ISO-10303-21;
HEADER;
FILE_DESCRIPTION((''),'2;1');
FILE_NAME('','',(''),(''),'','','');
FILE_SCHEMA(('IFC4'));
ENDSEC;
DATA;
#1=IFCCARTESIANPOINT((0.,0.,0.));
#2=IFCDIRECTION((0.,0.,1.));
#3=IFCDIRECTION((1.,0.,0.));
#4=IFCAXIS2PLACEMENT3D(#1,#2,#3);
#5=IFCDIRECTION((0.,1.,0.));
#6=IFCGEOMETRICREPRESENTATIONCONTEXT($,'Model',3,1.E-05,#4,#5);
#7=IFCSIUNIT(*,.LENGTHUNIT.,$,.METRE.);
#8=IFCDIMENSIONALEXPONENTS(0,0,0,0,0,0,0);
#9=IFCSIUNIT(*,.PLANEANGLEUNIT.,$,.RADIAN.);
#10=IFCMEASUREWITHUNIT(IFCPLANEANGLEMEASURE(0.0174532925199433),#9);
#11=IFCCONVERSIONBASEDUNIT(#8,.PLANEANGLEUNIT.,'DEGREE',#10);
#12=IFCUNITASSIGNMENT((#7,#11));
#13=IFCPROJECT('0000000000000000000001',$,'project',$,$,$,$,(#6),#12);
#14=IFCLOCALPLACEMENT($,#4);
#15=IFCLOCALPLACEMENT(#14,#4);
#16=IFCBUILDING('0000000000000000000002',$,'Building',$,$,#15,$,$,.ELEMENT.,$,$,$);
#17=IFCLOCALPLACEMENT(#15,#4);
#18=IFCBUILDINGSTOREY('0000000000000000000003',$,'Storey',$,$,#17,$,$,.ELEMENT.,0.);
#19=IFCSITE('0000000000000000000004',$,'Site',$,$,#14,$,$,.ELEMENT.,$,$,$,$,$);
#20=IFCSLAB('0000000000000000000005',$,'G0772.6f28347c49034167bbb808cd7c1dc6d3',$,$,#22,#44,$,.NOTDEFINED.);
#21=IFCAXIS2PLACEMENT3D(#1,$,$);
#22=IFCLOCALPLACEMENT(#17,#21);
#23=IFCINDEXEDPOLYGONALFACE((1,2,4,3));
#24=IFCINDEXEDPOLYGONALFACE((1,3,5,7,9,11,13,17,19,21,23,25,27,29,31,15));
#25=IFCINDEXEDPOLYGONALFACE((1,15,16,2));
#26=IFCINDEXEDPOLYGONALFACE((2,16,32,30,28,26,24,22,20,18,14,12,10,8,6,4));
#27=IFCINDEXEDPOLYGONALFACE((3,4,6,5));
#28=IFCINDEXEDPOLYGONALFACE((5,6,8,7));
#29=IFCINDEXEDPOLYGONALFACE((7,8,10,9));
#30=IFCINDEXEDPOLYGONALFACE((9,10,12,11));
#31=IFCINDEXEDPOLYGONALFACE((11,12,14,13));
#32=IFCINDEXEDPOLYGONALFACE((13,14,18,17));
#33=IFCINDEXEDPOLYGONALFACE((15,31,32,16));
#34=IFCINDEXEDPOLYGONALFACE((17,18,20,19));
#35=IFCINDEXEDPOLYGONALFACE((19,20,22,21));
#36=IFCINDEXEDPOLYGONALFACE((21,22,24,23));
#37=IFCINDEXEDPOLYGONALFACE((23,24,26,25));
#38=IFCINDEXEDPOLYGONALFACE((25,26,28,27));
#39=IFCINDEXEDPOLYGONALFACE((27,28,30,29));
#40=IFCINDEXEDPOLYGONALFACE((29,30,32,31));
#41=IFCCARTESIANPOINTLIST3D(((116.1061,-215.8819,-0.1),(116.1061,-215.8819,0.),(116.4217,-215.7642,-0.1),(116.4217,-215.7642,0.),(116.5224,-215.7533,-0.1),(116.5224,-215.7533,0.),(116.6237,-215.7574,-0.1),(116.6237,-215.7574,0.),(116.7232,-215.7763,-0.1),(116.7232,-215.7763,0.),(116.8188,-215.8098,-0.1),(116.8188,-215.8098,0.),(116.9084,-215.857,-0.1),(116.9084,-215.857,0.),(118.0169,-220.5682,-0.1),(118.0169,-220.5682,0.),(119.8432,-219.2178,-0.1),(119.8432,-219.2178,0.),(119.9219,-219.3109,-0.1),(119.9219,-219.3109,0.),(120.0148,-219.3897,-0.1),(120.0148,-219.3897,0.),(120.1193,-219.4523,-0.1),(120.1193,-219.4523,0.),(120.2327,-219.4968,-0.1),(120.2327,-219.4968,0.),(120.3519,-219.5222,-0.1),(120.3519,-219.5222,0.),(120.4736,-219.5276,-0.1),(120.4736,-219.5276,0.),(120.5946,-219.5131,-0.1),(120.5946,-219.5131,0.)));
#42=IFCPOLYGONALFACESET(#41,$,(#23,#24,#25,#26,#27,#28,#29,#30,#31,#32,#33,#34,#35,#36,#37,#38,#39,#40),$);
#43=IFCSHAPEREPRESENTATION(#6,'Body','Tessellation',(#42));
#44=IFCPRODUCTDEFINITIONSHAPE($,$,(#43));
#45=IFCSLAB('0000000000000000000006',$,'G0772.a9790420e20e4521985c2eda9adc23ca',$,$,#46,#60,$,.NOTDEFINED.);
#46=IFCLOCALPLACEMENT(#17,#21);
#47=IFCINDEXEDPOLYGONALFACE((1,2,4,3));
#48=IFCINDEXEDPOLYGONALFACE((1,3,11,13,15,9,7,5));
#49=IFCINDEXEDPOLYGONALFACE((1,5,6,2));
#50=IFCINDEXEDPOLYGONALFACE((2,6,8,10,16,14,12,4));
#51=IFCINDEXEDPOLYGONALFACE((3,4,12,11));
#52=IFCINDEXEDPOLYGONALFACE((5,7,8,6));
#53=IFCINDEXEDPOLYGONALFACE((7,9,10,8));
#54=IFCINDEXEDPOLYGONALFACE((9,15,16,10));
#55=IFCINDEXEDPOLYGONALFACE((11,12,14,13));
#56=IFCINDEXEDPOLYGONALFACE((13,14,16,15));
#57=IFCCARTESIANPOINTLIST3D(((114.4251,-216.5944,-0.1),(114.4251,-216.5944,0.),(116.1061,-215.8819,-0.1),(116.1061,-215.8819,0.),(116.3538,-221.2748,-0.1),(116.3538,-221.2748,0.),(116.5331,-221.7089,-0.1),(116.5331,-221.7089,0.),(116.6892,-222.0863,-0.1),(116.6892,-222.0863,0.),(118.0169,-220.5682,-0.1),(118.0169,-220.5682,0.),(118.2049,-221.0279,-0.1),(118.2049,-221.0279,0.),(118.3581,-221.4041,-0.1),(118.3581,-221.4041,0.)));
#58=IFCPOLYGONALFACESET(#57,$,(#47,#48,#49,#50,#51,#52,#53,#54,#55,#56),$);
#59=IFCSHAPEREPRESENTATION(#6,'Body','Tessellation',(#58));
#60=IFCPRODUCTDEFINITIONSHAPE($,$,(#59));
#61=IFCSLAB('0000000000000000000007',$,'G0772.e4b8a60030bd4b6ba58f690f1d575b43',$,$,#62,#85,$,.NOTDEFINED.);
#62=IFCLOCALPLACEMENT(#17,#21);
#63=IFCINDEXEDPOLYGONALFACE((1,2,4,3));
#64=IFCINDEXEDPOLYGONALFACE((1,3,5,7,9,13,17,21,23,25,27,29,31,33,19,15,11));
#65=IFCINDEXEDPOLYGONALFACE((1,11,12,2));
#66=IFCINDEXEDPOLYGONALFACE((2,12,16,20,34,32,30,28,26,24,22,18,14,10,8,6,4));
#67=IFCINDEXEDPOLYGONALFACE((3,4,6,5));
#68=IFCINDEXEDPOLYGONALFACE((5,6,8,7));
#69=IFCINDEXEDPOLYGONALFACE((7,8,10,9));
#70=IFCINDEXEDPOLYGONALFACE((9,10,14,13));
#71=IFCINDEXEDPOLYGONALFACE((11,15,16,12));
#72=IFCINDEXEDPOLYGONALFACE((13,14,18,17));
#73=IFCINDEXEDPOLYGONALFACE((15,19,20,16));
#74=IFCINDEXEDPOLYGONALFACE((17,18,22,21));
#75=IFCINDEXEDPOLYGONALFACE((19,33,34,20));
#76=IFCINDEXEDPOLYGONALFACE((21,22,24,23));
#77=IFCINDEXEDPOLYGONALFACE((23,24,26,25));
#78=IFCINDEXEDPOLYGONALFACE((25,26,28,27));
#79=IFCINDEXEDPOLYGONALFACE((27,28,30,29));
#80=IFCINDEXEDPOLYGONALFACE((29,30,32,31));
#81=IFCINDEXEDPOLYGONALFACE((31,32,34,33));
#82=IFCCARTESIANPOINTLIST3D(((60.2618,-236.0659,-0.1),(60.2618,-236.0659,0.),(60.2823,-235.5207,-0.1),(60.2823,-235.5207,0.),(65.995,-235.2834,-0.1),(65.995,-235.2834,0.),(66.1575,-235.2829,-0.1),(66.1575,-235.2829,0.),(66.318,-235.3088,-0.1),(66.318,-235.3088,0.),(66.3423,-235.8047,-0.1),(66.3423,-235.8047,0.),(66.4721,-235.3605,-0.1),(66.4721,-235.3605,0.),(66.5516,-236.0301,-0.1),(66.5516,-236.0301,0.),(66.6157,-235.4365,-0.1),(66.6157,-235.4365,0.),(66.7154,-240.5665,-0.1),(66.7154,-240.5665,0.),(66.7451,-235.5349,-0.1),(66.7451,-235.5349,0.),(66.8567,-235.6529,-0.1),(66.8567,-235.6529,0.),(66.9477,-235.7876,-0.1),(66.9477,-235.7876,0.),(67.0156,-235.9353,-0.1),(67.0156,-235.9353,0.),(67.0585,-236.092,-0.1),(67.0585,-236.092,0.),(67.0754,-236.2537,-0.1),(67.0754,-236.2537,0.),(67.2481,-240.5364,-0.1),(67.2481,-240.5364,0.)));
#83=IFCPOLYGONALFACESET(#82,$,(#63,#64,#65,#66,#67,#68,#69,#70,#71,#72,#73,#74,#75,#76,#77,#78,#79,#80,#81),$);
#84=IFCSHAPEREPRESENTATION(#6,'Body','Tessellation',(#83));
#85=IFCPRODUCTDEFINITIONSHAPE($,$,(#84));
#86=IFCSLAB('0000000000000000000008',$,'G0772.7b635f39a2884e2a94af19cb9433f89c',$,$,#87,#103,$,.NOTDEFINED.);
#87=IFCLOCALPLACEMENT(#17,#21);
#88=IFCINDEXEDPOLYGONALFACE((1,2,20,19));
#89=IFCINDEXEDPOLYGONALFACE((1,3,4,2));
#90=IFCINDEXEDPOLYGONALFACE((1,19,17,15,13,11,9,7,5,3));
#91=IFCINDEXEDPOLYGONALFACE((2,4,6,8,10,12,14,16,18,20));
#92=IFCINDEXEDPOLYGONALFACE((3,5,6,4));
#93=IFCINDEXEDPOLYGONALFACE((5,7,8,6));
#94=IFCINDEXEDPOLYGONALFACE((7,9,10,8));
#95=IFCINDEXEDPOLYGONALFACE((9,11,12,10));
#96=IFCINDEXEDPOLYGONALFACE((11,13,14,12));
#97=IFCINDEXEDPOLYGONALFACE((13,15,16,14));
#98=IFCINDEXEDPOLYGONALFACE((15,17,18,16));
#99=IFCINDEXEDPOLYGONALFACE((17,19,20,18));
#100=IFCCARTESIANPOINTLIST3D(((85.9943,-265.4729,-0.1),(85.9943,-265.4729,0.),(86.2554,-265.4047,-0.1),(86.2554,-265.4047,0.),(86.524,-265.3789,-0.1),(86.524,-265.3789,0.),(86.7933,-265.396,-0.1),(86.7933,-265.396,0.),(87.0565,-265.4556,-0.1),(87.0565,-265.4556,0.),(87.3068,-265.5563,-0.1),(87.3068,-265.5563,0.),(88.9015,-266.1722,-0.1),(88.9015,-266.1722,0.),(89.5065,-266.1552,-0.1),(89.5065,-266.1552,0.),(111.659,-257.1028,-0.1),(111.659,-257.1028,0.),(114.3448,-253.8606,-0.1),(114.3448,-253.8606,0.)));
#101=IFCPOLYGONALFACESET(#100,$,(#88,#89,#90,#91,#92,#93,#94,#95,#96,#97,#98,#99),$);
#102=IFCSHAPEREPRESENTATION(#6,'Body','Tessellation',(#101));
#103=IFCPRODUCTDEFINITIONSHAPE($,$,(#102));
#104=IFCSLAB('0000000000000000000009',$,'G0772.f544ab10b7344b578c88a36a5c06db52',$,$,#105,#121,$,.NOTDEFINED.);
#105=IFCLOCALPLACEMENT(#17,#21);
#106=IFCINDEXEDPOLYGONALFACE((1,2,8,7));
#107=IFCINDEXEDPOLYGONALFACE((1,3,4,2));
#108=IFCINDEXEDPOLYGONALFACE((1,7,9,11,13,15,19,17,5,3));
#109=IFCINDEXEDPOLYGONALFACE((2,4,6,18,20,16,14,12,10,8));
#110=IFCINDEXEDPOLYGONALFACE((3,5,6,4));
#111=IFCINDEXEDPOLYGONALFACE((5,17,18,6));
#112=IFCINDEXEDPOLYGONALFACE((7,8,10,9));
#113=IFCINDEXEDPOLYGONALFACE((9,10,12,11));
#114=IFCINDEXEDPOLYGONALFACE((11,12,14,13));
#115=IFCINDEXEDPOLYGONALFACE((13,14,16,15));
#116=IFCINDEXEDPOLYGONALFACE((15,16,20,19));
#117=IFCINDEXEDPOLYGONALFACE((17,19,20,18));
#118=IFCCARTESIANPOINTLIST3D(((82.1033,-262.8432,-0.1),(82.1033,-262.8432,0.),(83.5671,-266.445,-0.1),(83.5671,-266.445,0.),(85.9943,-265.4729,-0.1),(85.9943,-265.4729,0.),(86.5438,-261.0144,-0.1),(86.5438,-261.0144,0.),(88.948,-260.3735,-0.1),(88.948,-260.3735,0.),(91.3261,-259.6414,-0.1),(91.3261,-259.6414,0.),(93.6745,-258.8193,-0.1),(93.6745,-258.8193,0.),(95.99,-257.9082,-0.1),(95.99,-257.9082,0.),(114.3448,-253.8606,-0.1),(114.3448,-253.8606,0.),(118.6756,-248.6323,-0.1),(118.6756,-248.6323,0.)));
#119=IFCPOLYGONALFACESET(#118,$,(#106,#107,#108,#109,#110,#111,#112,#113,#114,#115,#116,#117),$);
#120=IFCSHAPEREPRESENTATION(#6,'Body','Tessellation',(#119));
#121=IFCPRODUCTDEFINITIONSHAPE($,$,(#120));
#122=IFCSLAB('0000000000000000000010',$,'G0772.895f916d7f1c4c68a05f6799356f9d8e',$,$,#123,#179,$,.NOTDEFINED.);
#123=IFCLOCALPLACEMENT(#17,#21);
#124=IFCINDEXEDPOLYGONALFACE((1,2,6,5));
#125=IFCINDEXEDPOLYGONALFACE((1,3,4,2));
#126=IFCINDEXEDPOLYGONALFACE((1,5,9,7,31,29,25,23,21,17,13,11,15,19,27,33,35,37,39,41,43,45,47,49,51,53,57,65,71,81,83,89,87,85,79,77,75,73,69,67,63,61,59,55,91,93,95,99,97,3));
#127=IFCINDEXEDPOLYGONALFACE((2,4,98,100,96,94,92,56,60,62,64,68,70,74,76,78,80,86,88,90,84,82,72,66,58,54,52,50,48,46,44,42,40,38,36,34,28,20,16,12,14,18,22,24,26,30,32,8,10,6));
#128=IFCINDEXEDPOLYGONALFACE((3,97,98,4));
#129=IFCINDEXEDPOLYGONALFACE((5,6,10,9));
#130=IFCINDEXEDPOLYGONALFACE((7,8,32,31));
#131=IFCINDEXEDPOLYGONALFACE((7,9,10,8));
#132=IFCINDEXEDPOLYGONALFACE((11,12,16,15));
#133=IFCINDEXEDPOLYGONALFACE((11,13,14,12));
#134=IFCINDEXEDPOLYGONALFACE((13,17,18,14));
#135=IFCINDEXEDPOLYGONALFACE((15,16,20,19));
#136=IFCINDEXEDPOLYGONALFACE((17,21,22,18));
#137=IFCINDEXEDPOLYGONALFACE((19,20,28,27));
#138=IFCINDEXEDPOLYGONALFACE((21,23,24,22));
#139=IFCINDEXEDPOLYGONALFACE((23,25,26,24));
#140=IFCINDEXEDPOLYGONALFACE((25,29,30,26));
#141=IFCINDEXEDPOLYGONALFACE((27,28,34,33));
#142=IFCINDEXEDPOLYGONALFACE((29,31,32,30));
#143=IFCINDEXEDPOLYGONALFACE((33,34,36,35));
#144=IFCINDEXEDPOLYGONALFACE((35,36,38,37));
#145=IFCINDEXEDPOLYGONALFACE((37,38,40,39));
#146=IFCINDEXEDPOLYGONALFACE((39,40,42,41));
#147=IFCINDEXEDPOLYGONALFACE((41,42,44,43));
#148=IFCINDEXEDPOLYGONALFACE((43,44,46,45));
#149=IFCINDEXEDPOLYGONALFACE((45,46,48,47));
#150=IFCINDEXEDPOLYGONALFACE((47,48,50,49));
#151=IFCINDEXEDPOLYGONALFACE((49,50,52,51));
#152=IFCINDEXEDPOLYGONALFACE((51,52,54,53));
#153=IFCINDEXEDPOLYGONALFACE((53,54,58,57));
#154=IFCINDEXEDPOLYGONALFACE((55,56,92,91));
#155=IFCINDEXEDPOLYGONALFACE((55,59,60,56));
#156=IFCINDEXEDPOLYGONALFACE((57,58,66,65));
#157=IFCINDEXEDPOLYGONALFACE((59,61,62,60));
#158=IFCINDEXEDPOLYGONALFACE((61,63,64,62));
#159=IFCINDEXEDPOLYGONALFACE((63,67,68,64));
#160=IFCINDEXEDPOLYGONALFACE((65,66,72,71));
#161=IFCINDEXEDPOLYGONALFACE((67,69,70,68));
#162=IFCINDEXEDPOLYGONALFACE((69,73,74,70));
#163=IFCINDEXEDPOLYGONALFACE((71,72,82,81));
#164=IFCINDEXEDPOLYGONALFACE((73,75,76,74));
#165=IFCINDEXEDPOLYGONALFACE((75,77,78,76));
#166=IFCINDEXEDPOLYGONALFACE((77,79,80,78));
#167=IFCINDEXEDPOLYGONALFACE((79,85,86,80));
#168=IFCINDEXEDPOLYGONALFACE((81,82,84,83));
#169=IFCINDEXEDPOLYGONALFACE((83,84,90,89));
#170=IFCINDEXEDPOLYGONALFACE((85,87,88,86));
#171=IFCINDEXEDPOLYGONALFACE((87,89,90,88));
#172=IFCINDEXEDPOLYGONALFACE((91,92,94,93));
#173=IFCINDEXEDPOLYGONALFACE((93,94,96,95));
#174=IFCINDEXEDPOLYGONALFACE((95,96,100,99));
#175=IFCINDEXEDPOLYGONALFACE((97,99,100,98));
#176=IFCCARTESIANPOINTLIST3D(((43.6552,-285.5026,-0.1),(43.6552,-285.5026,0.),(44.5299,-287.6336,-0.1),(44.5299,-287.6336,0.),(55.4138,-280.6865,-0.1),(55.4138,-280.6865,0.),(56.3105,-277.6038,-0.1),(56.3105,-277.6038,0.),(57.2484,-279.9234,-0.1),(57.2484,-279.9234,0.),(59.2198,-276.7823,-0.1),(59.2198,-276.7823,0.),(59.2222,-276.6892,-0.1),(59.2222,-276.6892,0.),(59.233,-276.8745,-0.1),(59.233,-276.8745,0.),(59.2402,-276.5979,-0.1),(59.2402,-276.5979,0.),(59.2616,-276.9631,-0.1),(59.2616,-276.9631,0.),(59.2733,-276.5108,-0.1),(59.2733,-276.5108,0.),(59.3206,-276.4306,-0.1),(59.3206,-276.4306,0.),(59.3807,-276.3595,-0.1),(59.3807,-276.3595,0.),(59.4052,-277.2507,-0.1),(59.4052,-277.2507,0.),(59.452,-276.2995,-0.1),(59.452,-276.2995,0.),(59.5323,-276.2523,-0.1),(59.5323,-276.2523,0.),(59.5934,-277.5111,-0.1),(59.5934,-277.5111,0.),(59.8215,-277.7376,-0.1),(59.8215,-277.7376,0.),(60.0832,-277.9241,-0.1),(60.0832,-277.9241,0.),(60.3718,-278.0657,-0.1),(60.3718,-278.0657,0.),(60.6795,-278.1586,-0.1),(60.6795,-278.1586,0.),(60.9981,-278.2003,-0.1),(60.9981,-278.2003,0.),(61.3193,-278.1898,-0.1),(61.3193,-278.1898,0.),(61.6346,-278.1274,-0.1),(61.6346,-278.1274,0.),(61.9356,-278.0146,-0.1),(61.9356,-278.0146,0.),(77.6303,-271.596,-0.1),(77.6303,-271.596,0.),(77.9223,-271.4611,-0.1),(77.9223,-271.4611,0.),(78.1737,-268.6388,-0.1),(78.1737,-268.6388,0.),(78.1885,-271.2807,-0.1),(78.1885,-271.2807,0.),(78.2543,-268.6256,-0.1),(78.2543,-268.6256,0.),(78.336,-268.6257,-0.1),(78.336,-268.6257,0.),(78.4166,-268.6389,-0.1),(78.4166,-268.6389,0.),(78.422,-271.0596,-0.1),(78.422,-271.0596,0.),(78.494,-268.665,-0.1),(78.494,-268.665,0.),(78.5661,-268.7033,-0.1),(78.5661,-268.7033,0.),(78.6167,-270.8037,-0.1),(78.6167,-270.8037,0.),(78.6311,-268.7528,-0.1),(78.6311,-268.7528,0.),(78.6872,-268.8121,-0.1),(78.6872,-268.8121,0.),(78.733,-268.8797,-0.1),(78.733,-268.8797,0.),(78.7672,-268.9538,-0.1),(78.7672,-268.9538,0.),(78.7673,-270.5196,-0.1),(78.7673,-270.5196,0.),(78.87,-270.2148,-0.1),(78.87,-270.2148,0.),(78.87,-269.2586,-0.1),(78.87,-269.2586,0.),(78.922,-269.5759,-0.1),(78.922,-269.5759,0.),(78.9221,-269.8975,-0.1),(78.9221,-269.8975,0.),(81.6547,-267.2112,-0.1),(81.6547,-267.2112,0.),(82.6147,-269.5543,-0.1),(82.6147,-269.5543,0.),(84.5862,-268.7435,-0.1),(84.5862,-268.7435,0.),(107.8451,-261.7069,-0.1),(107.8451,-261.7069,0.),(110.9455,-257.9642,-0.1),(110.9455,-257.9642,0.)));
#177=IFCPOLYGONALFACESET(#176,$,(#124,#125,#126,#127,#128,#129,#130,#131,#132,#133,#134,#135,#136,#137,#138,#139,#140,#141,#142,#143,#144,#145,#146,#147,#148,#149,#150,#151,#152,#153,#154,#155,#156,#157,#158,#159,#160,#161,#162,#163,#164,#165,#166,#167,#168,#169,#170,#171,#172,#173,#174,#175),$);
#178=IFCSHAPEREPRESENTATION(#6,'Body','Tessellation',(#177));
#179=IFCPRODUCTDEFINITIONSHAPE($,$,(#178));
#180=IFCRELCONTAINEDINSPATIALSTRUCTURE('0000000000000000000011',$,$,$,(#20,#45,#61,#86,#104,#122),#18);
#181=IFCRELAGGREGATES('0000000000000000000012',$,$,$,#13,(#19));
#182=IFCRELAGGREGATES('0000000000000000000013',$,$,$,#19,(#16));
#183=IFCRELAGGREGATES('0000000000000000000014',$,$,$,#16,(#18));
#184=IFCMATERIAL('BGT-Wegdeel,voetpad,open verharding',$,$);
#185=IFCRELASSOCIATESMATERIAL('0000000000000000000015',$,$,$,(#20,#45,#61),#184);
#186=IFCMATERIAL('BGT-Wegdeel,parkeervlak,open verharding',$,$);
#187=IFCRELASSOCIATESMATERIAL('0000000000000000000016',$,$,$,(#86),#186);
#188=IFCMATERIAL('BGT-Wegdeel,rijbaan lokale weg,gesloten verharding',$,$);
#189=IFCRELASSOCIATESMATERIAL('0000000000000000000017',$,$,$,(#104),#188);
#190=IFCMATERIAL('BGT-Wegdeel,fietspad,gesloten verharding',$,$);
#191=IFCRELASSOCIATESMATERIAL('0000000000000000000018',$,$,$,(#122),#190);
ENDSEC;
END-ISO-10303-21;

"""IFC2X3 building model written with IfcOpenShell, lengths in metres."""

from ifc_helpers import new_model, entity, si_unit, converted_unit, direction, frame, origin_with_axes, place, context, project, spatial, polyline, outline, extrude, material, element, save


model = new_model("IFC2X3")

# Units and contexts
model_context = context("Model", 3, precision=1e-05, world=origin_with_axes(), true_north=direction((0.0, 1.0, 0.0)))
ifc_project = project(units=[si_unit("LENGTHUNIT", "METRE"), converted_unit("PLANEANGLEUNIT", "DEGREE", entity("IfcPlaneAngleMeasure", 0.0174532925199433), si_unit("PLANEANGLEUNIT", "RADIAN"), dimensions=[0, 0, 0, 0, 0, 0, 0])], contexts=[model_context])

# Site, building, storey
site_placement = place(None, origin_with_axes())
site = spatial("IfcSite", under=ifc_project, at=site_placement, Name="Site", CompositionType="ELEMENT")
building_placement = place(site_placement, origin_with_axes())
building = spatial("IfcBuilding", under=site, at=building_placement, Name="Building", CompositionType="ELEMENT")
storey_placement = place(building_placement, origin_with_axes())
storey = spatial("IfcBuildingStorey", under=building, at=storey_placement, Name="Storey", CompositionType="ELEMENT", Elevation=0.0)

# Slabs
ifc_material_1 = material(Name="BGT-Wegdeel,voetpad,open verharding")
ifc_material_2 = material(Name="BGT-Wegdeel,parkeervlak,open verharding")
slab_1_placement = place(storey_placement, frame((0.0, 0.0, -0.1), z_axis=(0.0, 0.0, 1.0), x_axis=(1.0, 0.0, 0.0)))
element("IfcSlab", 1, at=slab_1_placement, inside=storey, material=ifc_material_1, Name="G0772.6f28347c49034167bbb808cd7c1dc6d3", PredefinedType="NOTDEFINED", context=model_context, shape_type="SweptSolid", body=[
    extrude(outline(polyline([(116.4217, -215.7642), (116.5224, -215.7533), (116.6237, -215.7574), (116.7232, -215.7763), (116.8188, -215.8098), (116.9084, -215.857), (119.8432, -219.2178), (119.9219, -219.3109), (120.0148, -219.3897), (120.1193, -219.4523), (120.2327, -219.4968), (120.3519, -219.5222), (120.4736, -219.5276), (120.5946, -219.5131), (118.0169, -220.5682), (116.1061, -215.8819), (116.4217, -215.7642)])), origin_with_axes(), (0.0, 0.0, 1.0), 0.1),
])
slab_2_placement = place(storey_placement, frame((0.0, 0.0, -0.1), z_axis=(0.0, 0.0, 1.0), x_axis=(1.0, 0.0, 0.0)))
element("IfcSlab", 2, at=slab_2_placement, inside=storey, material=ifc_material_1, Name="G0772.a9790420e20e4521985c2eda9adc23ca", PredefinedType="NOTDEFINED", context=model_context, shape_type="SweptSolid", body=[
    extrude(outline(polyline([(118.0169, -220.5682), (118.2049, -221.0279), (118.3581, -221.4041), (116.6892, -222.0863), (116.5331, -221.7089), (116.3538, -221.2748), (114.4251, -216.5944), (116.1061, -215.8819), (118.0169, -220.5682)])), origin_with_axes(), (0.0, 0.0, 1.0), 0.1),
])
slab_3_placement = place(storey_placement, frame((0.0, 0.0, -0.1), z_axis=(0.0, 0.0, 1.0), x_axis=(1.0, 0.0, 0.0)))
element("IfcSlab", 3, at=slab_3_placement, inside=storey, material=ifc_material_1, Name="G0772.e4b8a60030bd4b6ba58f690f1d575b43", PredefinedType="NOTDEFINED", context=model_context, shape_type="SweptSolid", body=[
    extrude(outline(polyline([(65.995, -235.2834), (66.1575, -235.2829), (66.318, -235.3088), (66.4721, -235.3605), (66.6157, -235.4365), (66.7451, -235.5349), (66.8567, -235.6529), (66.9477, -235.7876), (67.0156, -235.9353), (67.0585, -236.092), (67.0754, -236.2537), (67.2481, -240.5364), (66.7154, -240.5665), (66.5516, -236.0301), (66.3423, -235.8047), (60.2618, -236.0659), (60.2823, -235.5207), (65.995, -235.2834)])), origin_with_axes(), (0.0, 0.0, 1.0), 0.1),
])
slab_4_placement = place(storey_placement, frame((0.0, 0.0, -0.1), z_axis=(0.0, 0.0, 1.0), x_axis=(1.0, 0.0, 0.0)))
element("IfcSlab", 4, at=slab_4_placement, inside=storey, material=ifc_material_2, Name="G0772.7b635f39a2884e2a94af19cb9433f89c", PredefinedType="NOTDEFINED", context=model_context, shape_type="SweptSolid", body=[
    extrude(outline(polyline([(89.5065, -266.1552), (88.9015, -266.1722), (87.3068, -265.5563), (87.0565, -265.4556), (86.7933, -265.396), (86.524, -265.3789), (86.2554, -265.4047), (85.9943, -265.4729), (114.3448, -253.8606), (111.659, -257.1028), (89.5065, -266.1552)])), origin_with_axes(), (0.0, 0.0, 1.0), 0.1),
])
ifc_material_3 = material(Name="BGT-Wegdeel,rijbaan lokale weg,gesloten verharding")
slab_5_placement = place(storey_placement, frame((0.0, 0.0, -0.1), z_axis=(0.0, 0.0, 1.0), x_axis=(1.0, 0.0, 0.0)))
element("IfcSlab", 5, at=slab_5_placement, inside=storey, material=ifc_material_3, Name="G0772.f544ab10b7344b578c88a36a5c06db52", PredefinedType="NOTDEFINED", context=model_context, shape_type="SweptSolid", body=[
    extrude(outline(polyline([(85.9943, -265.4729), (83.5671, -266.445), (82.1033, -262.8432), (86.5438, -261.0144), (88.948, -260.3735), (91.3261, -259.6414), (93.6745, -258.8193), (95.99, -257.9082), (118.6756, -248.6323), (114.3448, -253.8606), (85.9943, -265.4729)])), origin_with_axes(), (0.0, 0.0, 1.0), 0.1),
])
ifc_material_4 = material(Name="BGT-Wegdeel,fietspad,gesloten verharding")
slab_6_placement = place(storey_placement, frame((0.0, 0.0, -0.1), z_axis=(0.0, 0.0, 1.0), x_axis=(1.0, 0.0, 0.0)))
element("IfcSlab", 6, at=slab_6_placement, inside=storey, material=ifc_material_4, Name="G0772.895f916d7f1c4c68a05f6799356f9d8e", PredefinedType="NOTDEFINED", context=model_context, shape_type="SweptSolid", body=[
    extrude(outline(polyline([(44.5299, -287.6336), (43.6552, -285.5026), (55.4138, -280.6865), (57.2484, -279.9234), (56.3105, -277.6038), (59.5323, -276.2523), (59.452, -276.2995), (59.3807, -276.3595), (59.3206, -276.4306), (59.2733, -276.5108), (59.2402, -276.5979), (59.2222, -276.6892), (59.2198, -276.7823), (59.233, -276.8745), (59.2616, -276.9631), (59.4052, -277.2507), (59.5934, -277.5111), (59.8215, -277.7376), (60.0832, -277.9241), (60.3718, -278.0657), (60.6795, -278.1586), (60.9981, -278.2003), (61.3193, -278.1898), (61.6346, -278.1274), (61.9356, -278.0146), (77.6303, -271.596), (77.9223, -271.4611), (78.1885, -271.2807), (78.422, -271.0596), (78.6167, -270.8037), (78.7673, -270.5196), (78.87, -270.2148), (78.9221, -269.8975), (78.922, -269.5759), (78.87, -269.2586), (78.7672, -268.9538), (78.733, -268.8797), (78.6872, -268.8121), (78.6311, -268.7528), (78.5661, -268.7033), (78.494, -268.665), (78.4166, -268.6389), (78.336, -268.6257), (78.2543, -268.6256), (78.1737, -268.6388), (81.6547, -267.2112), (82.6147, -269.5543), (84.5862, -268.7435), (110.9455, -257.9642), (107.8451, -261.7069), (44.5299, -287.6336)])), origin_with_axes(), (0.0, 0.0, 1.0), 0.1),
])

save(model, "model.ifc")
